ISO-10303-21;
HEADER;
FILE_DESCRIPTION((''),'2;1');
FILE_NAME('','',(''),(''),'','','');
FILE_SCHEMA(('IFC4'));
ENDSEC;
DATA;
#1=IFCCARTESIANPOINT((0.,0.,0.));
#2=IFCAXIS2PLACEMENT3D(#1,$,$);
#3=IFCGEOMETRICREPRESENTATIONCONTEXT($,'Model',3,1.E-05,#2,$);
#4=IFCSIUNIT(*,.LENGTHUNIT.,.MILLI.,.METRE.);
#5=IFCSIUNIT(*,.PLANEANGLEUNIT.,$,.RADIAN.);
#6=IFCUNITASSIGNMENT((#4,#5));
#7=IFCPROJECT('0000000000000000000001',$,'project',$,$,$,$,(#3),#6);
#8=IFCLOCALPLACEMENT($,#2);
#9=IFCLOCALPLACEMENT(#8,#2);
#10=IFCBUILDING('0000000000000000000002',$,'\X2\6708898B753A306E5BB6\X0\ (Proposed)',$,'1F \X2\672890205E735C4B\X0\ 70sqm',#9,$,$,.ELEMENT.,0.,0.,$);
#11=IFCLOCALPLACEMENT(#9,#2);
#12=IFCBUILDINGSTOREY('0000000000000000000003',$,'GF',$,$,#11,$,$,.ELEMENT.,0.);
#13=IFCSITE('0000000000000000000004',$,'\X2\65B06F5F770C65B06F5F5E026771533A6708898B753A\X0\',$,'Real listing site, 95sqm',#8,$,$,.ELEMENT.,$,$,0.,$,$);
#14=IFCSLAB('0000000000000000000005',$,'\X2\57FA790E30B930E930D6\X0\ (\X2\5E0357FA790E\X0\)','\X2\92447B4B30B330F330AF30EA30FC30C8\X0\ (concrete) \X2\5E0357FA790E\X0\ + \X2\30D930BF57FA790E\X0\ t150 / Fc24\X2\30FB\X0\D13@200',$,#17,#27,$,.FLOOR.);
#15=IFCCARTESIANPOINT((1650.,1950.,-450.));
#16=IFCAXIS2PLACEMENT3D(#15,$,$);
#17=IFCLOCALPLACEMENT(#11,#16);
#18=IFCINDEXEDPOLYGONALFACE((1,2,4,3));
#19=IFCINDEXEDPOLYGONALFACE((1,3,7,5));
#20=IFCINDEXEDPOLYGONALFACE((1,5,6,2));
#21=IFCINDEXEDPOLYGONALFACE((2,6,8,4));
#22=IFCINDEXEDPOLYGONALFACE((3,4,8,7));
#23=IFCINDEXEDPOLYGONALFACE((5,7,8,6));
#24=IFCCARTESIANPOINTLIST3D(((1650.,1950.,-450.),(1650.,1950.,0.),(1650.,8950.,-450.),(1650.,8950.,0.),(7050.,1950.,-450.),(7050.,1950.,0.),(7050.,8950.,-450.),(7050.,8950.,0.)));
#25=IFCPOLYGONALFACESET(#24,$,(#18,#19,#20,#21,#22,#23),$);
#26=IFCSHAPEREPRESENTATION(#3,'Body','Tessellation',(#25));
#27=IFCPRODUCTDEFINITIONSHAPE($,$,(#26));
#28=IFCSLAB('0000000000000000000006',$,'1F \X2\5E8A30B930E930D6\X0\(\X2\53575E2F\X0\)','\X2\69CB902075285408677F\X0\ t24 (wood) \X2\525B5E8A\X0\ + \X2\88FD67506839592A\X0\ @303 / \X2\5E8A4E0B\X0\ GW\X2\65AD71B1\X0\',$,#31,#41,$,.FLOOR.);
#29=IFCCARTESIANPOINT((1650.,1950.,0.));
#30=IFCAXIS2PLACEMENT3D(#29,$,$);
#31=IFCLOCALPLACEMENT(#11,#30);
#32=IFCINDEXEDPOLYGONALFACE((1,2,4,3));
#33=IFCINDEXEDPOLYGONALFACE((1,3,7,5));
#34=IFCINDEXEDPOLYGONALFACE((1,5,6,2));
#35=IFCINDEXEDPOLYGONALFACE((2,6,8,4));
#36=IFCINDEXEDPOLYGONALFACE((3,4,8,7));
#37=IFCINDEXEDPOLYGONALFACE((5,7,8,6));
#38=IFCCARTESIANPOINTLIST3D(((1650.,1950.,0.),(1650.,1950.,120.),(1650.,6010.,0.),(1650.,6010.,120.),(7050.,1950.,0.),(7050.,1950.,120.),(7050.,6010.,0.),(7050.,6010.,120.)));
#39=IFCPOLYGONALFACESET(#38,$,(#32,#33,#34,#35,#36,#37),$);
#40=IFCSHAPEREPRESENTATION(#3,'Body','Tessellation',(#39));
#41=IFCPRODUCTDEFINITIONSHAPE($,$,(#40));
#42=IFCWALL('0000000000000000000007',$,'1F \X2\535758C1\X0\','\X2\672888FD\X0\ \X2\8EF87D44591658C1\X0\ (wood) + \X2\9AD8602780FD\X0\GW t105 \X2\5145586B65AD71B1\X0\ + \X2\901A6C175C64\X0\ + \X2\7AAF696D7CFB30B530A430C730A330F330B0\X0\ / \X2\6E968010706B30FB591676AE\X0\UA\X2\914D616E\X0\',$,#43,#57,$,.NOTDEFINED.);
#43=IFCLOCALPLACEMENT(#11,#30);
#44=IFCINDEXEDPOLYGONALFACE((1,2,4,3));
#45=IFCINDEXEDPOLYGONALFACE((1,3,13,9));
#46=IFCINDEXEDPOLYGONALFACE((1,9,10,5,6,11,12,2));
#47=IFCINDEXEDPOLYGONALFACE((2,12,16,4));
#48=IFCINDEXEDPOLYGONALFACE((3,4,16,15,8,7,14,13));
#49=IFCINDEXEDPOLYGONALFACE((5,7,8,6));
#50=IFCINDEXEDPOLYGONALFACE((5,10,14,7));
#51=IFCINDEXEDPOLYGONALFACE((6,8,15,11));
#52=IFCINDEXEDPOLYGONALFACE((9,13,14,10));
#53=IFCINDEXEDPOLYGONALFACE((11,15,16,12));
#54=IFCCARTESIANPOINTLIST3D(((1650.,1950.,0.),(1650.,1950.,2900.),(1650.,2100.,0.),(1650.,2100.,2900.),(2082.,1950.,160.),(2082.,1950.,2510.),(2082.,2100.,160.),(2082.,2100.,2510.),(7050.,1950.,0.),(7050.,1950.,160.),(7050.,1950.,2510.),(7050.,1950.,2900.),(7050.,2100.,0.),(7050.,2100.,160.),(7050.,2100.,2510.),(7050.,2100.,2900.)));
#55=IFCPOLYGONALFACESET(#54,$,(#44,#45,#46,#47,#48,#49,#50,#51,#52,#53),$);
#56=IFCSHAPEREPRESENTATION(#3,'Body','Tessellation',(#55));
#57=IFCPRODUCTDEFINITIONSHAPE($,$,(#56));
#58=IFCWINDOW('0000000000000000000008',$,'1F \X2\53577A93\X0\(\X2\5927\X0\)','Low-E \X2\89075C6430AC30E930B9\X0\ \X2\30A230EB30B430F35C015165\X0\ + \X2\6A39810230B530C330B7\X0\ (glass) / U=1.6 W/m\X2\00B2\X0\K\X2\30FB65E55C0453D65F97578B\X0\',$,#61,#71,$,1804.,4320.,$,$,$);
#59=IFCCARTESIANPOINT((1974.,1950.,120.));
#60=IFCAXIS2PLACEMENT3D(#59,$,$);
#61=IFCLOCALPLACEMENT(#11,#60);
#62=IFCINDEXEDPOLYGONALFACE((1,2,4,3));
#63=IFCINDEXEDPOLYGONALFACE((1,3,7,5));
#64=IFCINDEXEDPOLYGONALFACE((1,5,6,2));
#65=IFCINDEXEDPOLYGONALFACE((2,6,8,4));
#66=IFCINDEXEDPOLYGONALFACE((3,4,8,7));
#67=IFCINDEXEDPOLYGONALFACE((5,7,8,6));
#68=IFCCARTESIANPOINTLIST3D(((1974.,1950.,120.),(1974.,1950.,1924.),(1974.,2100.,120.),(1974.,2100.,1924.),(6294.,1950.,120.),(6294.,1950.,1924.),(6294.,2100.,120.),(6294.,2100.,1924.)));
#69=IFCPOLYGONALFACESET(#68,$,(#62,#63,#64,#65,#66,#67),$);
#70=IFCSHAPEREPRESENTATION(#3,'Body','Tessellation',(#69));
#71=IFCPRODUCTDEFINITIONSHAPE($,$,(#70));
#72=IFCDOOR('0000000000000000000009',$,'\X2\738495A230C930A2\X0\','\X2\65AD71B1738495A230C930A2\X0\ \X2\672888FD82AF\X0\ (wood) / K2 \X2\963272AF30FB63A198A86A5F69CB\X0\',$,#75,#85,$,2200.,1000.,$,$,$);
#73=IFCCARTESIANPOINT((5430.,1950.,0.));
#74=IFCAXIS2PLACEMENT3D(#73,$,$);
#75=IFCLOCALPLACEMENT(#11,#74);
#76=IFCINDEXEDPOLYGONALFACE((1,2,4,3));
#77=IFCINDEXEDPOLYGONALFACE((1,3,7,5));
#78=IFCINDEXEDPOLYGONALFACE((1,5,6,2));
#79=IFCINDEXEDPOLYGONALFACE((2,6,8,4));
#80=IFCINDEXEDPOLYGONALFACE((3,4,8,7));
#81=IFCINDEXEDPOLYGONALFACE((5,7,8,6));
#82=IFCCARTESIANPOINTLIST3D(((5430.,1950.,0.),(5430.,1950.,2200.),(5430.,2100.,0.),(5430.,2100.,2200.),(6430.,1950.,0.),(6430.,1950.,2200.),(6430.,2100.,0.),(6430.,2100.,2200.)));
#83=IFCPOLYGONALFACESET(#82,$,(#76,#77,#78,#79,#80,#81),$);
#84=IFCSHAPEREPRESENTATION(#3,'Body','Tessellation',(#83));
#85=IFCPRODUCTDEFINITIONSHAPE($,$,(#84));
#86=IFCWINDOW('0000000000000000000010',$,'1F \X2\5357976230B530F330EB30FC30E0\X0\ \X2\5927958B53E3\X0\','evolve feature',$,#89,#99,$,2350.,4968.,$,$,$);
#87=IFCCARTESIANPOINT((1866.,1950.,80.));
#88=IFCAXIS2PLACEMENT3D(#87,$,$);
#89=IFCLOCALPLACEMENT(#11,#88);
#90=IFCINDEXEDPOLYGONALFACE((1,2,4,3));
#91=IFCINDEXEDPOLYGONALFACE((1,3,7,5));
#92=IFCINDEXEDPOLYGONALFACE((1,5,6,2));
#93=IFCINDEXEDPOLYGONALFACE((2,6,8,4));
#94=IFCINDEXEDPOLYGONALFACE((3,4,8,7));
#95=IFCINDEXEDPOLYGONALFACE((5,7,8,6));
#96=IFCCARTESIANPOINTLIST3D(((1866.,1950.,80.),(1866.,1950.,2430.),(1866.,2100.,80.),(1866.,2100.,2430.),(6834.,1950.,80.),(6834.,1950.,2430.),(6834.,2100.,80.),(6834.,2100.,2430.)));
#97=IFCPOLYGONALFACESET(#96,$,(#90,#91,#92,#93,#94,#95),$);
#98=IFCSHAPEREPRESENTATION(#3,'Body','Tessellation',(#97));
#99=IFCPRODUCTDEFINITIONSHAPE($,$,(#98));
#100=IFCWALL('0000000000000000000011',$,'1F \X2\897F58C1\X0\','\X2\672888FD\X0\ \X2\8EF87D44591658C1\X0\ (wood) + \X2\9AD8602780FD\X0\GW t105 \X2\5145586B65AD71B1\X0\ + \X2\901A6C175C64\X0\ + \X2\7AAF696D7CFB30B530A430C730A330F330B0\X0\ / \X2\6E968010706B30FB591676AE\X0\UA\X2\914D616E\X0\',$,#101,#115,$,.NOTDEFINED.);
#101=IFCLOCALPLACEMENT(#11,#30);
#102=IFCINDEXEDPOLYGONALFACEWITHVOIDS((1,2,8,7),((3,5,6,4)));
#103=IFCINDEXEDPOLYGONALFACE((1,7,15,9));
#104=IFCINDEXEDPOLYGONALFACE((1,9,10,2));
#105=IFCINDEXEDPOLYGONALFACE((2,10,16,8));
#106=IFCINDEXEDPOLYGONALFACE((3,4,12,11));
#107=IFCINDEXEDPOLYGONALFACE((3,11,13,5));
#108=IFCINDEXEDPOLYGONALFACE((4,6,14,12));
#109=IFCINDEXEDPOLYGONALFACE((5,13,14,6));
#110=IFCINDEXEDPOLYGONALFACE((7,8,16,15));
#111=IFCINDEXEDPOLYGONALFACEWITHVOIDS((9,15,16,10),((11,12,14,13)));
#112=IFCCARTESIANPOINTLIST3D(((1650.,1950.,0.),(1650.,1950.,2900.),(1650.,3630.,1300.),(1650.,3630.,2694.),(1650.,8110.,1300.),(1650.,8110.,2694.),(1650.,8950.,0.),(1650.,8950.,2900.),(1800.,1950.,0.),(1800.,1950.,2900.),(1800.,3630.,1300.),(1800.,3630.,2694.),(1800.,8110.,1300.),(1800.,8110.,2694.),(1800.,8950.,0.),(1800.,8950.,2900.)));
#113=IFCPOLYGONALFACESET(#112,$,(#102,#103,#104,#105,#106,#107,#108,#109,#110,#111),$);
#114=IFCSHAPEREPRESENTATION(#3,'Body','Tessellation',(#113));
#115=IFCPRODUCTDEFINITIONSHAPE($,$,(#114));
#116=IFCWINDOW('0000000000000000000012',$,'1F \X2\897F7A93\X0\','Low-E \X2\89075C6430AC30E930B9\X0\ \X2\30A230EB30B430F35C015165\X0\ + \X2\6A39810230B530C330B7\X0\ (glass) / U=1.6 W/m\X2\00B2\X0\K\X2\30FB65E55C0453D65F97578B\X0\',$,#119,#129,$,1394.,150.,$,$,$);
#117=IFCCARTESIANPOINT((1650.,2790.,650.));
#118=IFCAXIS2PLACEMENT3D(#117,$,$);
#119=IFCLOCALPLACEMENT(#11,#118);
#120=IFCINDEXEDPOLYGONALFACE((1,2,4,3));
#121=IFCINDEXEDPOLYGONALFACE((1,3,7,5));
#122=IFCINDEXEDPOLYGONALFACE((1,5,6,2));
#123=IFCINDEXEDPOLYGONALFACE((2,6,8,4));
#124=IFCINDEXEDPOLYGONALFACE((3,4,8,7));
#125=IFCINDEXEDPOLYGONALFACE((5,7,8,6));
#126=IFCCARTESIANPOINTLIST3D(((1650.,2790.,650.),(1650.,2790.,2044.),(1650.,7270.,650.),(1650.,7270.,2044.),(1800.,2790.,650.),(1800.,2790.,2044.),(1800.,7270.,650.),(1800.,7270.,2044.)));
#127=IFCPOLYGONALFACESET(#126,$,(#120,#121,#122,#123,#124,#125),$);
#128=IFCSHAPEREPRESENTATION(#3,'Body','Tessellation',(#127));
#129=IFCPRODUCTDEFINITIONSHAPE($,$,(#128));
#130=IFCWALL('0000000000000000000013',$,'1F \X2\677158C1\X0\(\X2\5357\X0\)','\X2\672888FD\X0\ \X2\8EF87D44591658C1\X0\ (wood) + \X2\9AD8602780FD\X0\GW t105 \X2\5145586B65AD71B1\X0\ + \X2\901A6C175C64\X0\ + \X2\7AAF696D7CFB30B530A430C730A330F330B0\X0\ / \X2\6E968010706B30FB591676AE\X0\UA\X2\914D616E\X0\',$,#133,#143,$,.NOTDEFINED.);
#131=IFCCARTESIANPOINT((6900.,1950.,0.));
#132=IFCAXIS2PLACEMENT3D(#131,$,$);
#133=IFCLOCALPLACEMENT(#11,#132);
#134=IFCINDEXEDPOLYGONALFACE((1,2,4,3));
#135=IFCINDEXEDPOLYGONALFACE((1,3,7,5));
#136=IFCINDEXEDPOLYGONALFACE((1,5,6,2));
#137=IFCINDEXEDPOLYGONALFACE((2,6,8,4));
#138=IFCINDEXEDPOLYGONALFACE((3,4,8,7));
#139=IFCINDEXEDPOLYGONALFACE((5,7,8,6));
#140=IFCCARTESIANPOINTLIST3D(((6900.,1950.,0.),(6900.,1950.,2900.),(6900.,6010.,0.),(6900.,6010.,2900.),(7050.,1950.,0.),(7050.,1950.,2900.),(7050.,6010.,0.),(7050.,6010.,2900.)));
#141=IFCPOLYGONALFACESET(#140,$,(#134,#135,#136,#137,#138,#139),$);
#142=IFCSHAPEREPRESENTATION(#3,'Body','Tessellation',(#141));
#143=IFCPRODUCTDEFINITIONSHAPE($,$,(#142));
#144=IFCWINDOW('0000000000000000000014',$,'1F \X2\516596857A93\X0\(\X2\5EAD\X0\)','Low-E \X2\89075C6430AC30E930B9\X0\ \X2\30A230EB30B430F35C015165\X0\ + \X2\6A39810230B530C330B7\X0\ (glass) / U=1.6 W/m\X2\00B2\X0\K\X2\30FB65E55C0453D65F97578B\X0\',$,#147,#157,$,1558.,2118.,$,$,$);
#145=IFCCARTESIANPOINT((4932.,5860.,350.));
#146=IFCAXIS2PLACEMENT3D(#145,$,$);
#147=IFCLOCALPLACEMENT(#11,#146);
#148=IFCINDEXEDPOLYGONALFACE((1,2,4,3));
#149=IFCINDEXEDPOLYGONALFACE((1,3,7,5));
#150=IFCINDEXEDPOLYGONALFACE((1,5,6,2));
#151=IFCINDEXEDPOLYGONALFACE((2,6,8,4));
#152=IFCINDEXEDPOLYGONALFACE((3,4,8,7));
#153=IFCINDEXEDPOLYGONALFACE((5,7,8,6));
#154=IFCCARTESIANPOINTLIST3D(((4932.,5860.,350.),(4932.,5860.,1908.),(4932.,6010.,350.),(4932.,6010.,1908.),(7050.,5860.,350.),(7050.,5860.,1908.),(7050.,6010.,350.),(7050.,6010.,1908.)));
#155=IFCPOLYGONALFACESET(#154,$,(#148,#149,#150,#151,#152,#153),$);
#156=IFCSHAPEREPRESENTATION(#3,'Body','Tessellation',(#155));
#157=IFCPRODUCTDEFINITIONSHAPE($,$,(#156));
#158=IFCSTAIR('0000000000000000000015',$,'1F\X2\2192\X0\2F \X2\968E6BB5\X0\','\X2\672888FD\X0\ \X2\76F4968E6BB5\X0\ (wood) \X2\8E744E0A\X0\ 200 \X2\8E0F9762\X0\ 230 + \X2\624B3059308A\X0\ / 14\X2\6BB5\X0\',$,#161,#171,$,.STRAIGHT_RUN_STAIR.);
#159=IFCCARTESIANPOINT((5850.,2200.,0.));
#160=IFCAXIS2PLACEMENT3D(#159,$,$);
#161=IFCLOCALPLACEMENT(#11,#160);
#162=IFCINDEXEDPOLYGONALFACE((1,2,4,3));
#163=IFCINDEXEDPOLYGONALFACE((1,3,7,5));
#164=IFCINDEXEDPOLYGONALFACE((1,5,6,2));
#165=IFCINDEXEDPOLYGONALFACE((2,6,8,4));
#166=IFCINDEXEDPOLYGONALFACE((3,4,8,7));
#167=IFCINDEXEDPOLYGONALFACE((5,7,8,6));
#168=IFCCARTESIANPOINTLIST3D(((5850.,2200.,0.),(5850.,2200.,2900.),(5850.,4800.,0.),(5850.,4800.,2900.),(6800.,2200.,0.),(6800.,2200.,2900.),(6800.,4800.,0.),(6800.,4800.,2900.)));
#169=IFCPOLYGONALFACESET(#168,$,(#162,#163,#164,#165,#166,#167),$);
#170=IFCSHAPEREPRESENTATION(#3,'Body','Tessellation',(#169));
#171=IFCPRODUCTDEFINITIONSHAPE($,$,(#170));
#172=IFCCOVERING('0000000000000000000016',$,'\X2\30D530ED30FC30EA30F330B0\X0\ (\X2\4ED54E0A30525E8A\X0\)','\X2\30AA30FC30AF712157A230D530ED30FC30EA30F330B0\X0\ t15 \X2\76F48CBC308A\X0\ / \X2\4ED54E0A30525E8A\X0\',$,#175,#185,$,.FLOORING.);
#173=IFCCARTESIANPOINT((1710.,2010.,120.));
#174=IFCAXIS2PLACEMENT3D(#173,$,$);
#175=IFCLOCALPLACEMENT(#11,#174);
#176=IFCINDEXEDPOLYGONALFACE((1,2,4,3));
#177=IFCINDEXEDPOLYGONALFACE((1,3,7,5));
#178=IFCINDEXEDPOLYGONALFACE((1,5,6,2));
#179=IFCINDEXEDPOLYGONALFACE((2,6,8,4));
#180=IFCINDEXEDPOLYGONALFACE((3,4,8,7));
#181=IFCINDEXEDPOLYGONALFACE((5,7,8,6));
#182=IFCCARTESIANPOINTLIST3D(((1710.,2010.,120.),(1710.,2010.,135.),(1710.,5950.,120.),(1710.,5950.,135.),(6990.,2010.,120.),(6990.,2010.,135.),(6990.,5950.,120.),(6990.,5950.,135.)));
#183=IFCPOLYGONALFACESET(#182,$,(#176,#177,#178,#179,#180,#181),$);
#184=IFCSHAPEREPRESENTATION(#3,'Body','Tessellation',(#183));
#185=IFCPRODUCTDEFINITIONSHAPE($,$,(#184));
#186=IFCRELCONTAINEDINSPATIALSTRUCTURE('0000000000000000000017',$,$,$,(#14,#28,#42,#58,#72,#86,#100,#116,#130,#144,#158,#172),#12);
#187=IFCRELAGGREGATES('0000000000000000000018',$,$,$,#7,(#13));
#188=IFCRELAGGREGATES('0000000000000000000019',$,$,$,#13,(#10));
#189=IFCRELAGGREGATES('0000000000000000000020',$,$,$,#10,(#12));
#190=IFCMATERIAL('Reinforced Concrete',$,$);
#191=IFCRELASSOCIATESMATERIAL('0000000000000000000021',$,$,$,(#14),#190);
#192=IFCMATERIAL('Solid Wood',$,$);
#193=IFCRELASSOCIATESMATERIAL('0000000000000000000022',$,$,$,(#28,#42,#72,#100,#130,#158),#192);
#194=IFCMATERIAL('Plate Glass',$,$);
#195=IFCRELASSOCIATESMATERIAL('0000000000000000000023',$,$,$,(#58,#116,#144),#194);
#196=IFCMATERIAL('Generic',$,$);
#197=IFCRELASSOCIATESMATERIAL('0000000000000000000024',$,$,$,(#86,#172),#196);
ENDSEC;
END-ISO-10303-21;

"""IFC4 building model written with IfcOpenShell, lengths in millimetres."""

from ifc_helpers import new_model, si_unit, frame, frame_2d, origin, place, context, project, spatial, rectangle, extrude, material, element, fill, save


model = new_model("IFC4")

# Units and contexts
model_context = context("Model", 3, precision=1e-05, world=origin())
ifc_project = project(units=[si_unit("LENGTHUNIT", "METRE", prefix="MILLI"), si_unit("PLANEANGLEUNIT", "RADIAN")], contexts=[model_context])

# Site, building, storey
site_placement = place(None, origin())
site = spatial("IfcSite", under=ifc_project, at=site_placement, Name="新潟県新潟市東区月見町", ObjectType="Real listing site, 95sqm", CompositionType="ELEMENT", RefElevation=0.0)
building_placement = place(site_placement, origin())
building = spatial("IfcBuilding", under=site, at=building_placement, Name="月見町の家 (Proposed)", ObjectType="1F 木造平屋 70sqm", CompositionType="ELEMENT", ElevationOfRefHeight=0.0, ElevationOfTerrain=0.0)
storey_placement = place(building_placement, origin())
storey = spatial("IfcBuildingStorey", under=building, at=storey_placement, Name="GF", CompositionType="ELEMENT", Elevation=0.0)

# Slabs
ifc_material_1 = material(Name="Reinforced Concrete")
slab_1_placement = place(storey_placement, frame((1650.0, 1950.0, -450.0)))
element("IfcSlab", 1, at=slab_1_placement, inside=storey, material=ifc_material_1, Name="基礎スラブ (布基礎)", Description="鉄筋コンクリート (concrete) 布基礎 + ベタ基礎 t150 / Fc24・D13@200", PredefinedType="FLOOR", context=model_context, shape_type="SweptSolid", body=[
    extrude(rectangle(XDim=5400.0, YDim=7000.0, at=frame_2d((2700.0, 3500.0))), frame((1650.0, 1950.0, -450.0)), (0.0, 0.0, 1.0), 450.0),
])
ifc_material_2 = material(Name="Solid Wood")
slab_2_placement = place(storey_placement, frame((1650.0, 1950.0, 0.0)))
element("IfcSlab", 2, at=slab_2_placement, inside=storey, material=ifc_material_2, Name="1F 床スラブ(南帯)", Description="構造用合板 t24 (wood) 剛床 + 製材根太 @303 / 床下 GW断熱", PredefinedType="FLOOR", context=model_context, shape_type="SweptSolid", body=[
    extrude(rectangle(XDim=5400.0, YDim=4060.0, at=frame_2d((2700.0, 2030.0))), frame((1650.0, 1950.0, 0.0)), (0.0, 0.0, 1.0), 120.0),
])

# Wall, openings, windows, door
wall_1_placement = place(storey_placement, frame((1650.0, 1950.0, 0.0)))
wall_1 = element("IfcWall", 3, at=wall_1_placement, inside=storey, material=ifc_material_2, Name="1F 南壁", Description="木製 軸組外壁 (wood) + 高性能GW t105 充填断熱 + 通気層 + 窯業系サイディング / 準耐火・外皮UA配慮", PredefinedType="NOTDEFINED", context=model_context, shape_type="SweptSolid", body=[
    extrude(rectangle(XDim=5400.0, YDim=150.0, at=frame_2d((2700.0, 75.0))), frame((1650.0, 1950.0, 0.0)), (0.0, 0.0, 1.0), 2900.0),
])
opening_1_placement = place(storey_placement, frame((1974.0, 1950.0, 120.0)))
opening_1 = element("IfcOpeningElement", 4, at=opening_1_placement, cuts=wall_1, PredefinedType="NOTDEFINED", context=model_context, shape_type="SweptSolid", body=[
    extrude(rectangle(XDim=4320.0, YDim=150.0, at=frame_2d((2160.0, 75.0))), frame((1974.0, 1950.0, 120.0)), (0.0, 0.0, 1.0), 1804.0),
])
opening_2_placement = place(storey_placement, frame((5430.0, 1950.0, 0.0)))
opening_2 = element("IfcOpeningElement", 5, at=opening_2_placement, cuts=wall_1, PredefinedType="NOTDEFINED", context=model_context, shape_type="SweptSolid", body=[
    extrude(rectangle(XDim=1000.0, YDim=150.0, at=frame_2d((500.0, 75.0))), frame((5430.0, 1950.0, 0.0)), (0.0, 0.0, 1.0), 2200.0),
])
opening_3_placement = place(storey_placement, frame((1866.0, 1950.0, 80.0)))
opening_3 = element("IfcOpeningElement", 6, at=opening_3_placement, cuts=wall_1, PredefinedType="NOTDEFINED", context=model_context, shape_type="SweptSolid", body=[
    extrude(rectangle(XDim=4968.0, YDim=150.0, at=frame_2d((2484.0, 75.0))), frame((1866.0, 1950.0, 80.0)), (0.0, 0.0, 1.0), 2350.0),
])
ifc_material_3 = material(Name="Plate Glass")
window_1_placement = place(storey_placement, frame((1974.0, 1950.0, 120.0)))
window_1 = element("IfcWindow", 7, at=window_1_placement, inside=storey, material=ifc_material_3, Name="1F 南窓(大)", Description="Low-E 複層ガラス アルゴン封入 + 樹脂サッシ (glass) / U=1.6 W/m²K・日射取得型", OverallHeight=1804.0, OverallWidth=4320.0, context=model_context, shape_type="SweptSolid", body=[
    extrude(rectangle(XDim=4320.0, YDim=150.0, at=frame_2d((2160.0, 75.0))), frame((1974.0, 1950.0, 120.0)), (0.0, 0.0, 1.0), 1804.0),
])
fill(opening_1, window_1)
door_1_placement = place(storey_placement, frame((5430.0, 1950.0, 0.0)))
door_1 = element("IfcDoor", 8, at=door_1_placement, inside=storey, material=ifc_material_2, Name="玄関ドア", Description="断熱玄関ドア 木製芯 (wood) / K2 防犯・採風機構", OverallHeight=2200.0, OverallWidth=1000.0, context=model_context, shape_type="SweptSolid", body=[
    extrude(rectangle(XDim=1000.0, YDim=150.0, at=frame_2d((500.0, 75.0))), frame((5430.0, 1950.0, 0.0)), (0.0, 0.0, 1.0), 2200.0),
])
fill(opening_2, door_1)
ifc_material_4 = material(Name="Generic")
window_2_placement = place(storey_placement, frame((1866.0, 1950.0, 80.0)))
window_2 = element("IfcWindow", 9, at=window_2_placement, inside=storey, material=ifc_material_4, Name="1F 南面サンルーム 大開口", Description="evolve feature", OverallHeight=2350.0, OverallWidth=4968.0, context=model_context, shape_type="SweptSolid", body=[
    extrude(rectangle(XDim=4968.0, YDim=150.0, at=frame_2d((2484.0, 75.0))), frame((1866.0, 1950.0, 80.0)), (0.0, 0.0, 1.0), 2350.0),
])
fill(opening_3, window_2)

# Walls, openings, windows
wall_2_placement = place(storey_placement, frame((1650.0, 1950.0, 0.0)))
wall_2 = element("IfcWall", 10, at=wall_2_placement, inside=storey, material=ifc_material_2, Name="1F 西壁", Description="木製 軸組外壁 (wood) + 高性能GW t105 充填断熱 + 通気層 + 窯業系サイディング / 準耐火・外皮UA配慮", PredefinedType="NOTDEFINED", context=model_context, shape_type="SweptSolid", body=[
    extrude(rectangle(XDim=150.0, YDim=7000.0, at=frame_2d((75.0, 3500.0))), frame((1650.0, 1950.0, 0.0)), (0.0, 0.0, 1.0), 2900.0),
])
opening_4_placement = place(storey_placement, frame((1650.0, 2790.0, 650.0)))
opening_4 = element("IfcOpeningElement", 11, at=opening_4_placement, cuts=wall_2, PredefinedType="NOTDEFINED", context=model_context, shape_type="SweptSolid", body=[
    extrude(rectangle(XDim=150.0, YDim=4480.0, at=frame_2d((75.0, 2240.0))), frame((1650.0, 2790.0, 650.0)), (0.0, 0.0, 1.0), 1394.0),
])
window_3_placement = place(storey_placement, frame((1650.0, 2790.0, 650.0)))
window_3 = element("IfcWindow", 12, at=window_3_placement, inside=storey, material=ifc_material_3, Name="1F 西窓", Description="Low-E 複層ガラス アルゴン封入 + 樹脂サッシ (glass) / U=1.6 W/m²K・日射取得型", OverallHeight=1394.0, OverallWidth=150.0, context=model_context, shape_type="SweptSolid", body=[
    extrude(rectangle(XDim=150.0, YDim=4480.0, at=frame_2d((75.0, 2240.0))), frame((1650.0, 2790.0, 650.0)), (0.0, 0.0, 1.0), 1394.0),
])
fill(opening_4, window_3)
wall_3_placement = place(storey_placement, frame((6900.0, 1950.0, 0.0)))
wall_3 = element("IfcWall", 13, at=wall_3_placement, inside=storey, material=ifc_material_2, Name="1F 東壁(南)", Description="木製 軸組外壁 (wood) + 高性能GW t105 充填断熱 + 通気層 + 窯業系サイディング / 準耐火・外皮UA配慮", PredefinedType="NOTDEFINED", context=model_context, shape_type="SweptSolid", body=[
    extrude(rectangle(XDim=150.0, YDim=4060.0, at=frame_2d((75.0, 2030.0))), frame((6900.0, 1950.0, 0.0)), (0.0, 0.0, 1.0), 2900.0),
])
opening_5_placement = place(storey_placement, frame((4932.0, 5860.0, 350.0)))
opening_5 = element("IfcOpeningElement", 14, at=opening_5_placement, cuts=wall_3, PredefinedType="NOTDEFINED", context=model_context, shape_type="SweptSolid", body=[
    extrude(rectangle(XDim=2118.0, YDim=150.0, at=frame_2d((1059.0, 75.0))), frame((4932.0, 5860.0, 350.0)), (0.0, 0.0, 1.0), 1558.0),
])
window_4_placement = place(storey_placement, frame((4932.0, 5860.0, 350.0)))
window_4 = element("IfcWindow", 15, at=window_4_placement, inside=storey, material=ifc_material_3, Name="1F 入隅窓(庭)", Description="Low-E 複層ガラス アルゴン封入 + 樹脂サッシ (glass) / U=1.6 W/m²K・日射取得型", OverallHeight=1558.0, OverallWidth=2118.0, context=model_context, shape_type="SweptSolid", body=[
    extrude(rectangle(XDim=2118.0, YDim=150.0, at=frame_2d((1059.0, 75.0))), frame((4932.0, 5860.0, 350.0)), (0.0, 0.0, 1.0), 1558.0),
])
fill(opening_5, window_4)

# Stair
stair_placement = place(storey_placement, frame((5850.0, 2200.0, 0.0)))
element("IfcStair", 16, at=stair_placement, inside=storey, material=ifc_material_2, Name="1F→2F 階段", Description="木製 直階段 (wood) 蹴上 200 踏面 230 + 手すり / 14段", PredefinedType="STRAIGHT_RUN_STAIR", context=model_context, shape_type="SweptSolid", body=[
    extrude(rectangle(XDim=950.0, YDim=2600.0, at=frame_2d((475.0, 1300.0))), frame((5850.0, 2200.0, 0.0)), (0.0, 0.0, 1.0), 2900.0),
])

# Covering
covering_placement = place(storey_placement, frame((1710.0, 2010.0, 120.0)))
element("IfcCovering", 17, at=covering_placement, inside=storey, material=ifc_material_4, Name="フローリング (仕上げ床)", Description="オーク無垢フローリング t15 直貼り / 仕上げ床", PredefinedType="FLOORING", context=model_context, shape_type="SweptSolid", body=[
    extrude(rectangle(XDim=5280.0, YDim=3940.0, at=frame_2d((2640.0, 1970.0))), frame((1710.0, 2010.0, 120.0)), (0.0, 0.0, 1.0), 15.0),
])

save(model, "model.ifc")
